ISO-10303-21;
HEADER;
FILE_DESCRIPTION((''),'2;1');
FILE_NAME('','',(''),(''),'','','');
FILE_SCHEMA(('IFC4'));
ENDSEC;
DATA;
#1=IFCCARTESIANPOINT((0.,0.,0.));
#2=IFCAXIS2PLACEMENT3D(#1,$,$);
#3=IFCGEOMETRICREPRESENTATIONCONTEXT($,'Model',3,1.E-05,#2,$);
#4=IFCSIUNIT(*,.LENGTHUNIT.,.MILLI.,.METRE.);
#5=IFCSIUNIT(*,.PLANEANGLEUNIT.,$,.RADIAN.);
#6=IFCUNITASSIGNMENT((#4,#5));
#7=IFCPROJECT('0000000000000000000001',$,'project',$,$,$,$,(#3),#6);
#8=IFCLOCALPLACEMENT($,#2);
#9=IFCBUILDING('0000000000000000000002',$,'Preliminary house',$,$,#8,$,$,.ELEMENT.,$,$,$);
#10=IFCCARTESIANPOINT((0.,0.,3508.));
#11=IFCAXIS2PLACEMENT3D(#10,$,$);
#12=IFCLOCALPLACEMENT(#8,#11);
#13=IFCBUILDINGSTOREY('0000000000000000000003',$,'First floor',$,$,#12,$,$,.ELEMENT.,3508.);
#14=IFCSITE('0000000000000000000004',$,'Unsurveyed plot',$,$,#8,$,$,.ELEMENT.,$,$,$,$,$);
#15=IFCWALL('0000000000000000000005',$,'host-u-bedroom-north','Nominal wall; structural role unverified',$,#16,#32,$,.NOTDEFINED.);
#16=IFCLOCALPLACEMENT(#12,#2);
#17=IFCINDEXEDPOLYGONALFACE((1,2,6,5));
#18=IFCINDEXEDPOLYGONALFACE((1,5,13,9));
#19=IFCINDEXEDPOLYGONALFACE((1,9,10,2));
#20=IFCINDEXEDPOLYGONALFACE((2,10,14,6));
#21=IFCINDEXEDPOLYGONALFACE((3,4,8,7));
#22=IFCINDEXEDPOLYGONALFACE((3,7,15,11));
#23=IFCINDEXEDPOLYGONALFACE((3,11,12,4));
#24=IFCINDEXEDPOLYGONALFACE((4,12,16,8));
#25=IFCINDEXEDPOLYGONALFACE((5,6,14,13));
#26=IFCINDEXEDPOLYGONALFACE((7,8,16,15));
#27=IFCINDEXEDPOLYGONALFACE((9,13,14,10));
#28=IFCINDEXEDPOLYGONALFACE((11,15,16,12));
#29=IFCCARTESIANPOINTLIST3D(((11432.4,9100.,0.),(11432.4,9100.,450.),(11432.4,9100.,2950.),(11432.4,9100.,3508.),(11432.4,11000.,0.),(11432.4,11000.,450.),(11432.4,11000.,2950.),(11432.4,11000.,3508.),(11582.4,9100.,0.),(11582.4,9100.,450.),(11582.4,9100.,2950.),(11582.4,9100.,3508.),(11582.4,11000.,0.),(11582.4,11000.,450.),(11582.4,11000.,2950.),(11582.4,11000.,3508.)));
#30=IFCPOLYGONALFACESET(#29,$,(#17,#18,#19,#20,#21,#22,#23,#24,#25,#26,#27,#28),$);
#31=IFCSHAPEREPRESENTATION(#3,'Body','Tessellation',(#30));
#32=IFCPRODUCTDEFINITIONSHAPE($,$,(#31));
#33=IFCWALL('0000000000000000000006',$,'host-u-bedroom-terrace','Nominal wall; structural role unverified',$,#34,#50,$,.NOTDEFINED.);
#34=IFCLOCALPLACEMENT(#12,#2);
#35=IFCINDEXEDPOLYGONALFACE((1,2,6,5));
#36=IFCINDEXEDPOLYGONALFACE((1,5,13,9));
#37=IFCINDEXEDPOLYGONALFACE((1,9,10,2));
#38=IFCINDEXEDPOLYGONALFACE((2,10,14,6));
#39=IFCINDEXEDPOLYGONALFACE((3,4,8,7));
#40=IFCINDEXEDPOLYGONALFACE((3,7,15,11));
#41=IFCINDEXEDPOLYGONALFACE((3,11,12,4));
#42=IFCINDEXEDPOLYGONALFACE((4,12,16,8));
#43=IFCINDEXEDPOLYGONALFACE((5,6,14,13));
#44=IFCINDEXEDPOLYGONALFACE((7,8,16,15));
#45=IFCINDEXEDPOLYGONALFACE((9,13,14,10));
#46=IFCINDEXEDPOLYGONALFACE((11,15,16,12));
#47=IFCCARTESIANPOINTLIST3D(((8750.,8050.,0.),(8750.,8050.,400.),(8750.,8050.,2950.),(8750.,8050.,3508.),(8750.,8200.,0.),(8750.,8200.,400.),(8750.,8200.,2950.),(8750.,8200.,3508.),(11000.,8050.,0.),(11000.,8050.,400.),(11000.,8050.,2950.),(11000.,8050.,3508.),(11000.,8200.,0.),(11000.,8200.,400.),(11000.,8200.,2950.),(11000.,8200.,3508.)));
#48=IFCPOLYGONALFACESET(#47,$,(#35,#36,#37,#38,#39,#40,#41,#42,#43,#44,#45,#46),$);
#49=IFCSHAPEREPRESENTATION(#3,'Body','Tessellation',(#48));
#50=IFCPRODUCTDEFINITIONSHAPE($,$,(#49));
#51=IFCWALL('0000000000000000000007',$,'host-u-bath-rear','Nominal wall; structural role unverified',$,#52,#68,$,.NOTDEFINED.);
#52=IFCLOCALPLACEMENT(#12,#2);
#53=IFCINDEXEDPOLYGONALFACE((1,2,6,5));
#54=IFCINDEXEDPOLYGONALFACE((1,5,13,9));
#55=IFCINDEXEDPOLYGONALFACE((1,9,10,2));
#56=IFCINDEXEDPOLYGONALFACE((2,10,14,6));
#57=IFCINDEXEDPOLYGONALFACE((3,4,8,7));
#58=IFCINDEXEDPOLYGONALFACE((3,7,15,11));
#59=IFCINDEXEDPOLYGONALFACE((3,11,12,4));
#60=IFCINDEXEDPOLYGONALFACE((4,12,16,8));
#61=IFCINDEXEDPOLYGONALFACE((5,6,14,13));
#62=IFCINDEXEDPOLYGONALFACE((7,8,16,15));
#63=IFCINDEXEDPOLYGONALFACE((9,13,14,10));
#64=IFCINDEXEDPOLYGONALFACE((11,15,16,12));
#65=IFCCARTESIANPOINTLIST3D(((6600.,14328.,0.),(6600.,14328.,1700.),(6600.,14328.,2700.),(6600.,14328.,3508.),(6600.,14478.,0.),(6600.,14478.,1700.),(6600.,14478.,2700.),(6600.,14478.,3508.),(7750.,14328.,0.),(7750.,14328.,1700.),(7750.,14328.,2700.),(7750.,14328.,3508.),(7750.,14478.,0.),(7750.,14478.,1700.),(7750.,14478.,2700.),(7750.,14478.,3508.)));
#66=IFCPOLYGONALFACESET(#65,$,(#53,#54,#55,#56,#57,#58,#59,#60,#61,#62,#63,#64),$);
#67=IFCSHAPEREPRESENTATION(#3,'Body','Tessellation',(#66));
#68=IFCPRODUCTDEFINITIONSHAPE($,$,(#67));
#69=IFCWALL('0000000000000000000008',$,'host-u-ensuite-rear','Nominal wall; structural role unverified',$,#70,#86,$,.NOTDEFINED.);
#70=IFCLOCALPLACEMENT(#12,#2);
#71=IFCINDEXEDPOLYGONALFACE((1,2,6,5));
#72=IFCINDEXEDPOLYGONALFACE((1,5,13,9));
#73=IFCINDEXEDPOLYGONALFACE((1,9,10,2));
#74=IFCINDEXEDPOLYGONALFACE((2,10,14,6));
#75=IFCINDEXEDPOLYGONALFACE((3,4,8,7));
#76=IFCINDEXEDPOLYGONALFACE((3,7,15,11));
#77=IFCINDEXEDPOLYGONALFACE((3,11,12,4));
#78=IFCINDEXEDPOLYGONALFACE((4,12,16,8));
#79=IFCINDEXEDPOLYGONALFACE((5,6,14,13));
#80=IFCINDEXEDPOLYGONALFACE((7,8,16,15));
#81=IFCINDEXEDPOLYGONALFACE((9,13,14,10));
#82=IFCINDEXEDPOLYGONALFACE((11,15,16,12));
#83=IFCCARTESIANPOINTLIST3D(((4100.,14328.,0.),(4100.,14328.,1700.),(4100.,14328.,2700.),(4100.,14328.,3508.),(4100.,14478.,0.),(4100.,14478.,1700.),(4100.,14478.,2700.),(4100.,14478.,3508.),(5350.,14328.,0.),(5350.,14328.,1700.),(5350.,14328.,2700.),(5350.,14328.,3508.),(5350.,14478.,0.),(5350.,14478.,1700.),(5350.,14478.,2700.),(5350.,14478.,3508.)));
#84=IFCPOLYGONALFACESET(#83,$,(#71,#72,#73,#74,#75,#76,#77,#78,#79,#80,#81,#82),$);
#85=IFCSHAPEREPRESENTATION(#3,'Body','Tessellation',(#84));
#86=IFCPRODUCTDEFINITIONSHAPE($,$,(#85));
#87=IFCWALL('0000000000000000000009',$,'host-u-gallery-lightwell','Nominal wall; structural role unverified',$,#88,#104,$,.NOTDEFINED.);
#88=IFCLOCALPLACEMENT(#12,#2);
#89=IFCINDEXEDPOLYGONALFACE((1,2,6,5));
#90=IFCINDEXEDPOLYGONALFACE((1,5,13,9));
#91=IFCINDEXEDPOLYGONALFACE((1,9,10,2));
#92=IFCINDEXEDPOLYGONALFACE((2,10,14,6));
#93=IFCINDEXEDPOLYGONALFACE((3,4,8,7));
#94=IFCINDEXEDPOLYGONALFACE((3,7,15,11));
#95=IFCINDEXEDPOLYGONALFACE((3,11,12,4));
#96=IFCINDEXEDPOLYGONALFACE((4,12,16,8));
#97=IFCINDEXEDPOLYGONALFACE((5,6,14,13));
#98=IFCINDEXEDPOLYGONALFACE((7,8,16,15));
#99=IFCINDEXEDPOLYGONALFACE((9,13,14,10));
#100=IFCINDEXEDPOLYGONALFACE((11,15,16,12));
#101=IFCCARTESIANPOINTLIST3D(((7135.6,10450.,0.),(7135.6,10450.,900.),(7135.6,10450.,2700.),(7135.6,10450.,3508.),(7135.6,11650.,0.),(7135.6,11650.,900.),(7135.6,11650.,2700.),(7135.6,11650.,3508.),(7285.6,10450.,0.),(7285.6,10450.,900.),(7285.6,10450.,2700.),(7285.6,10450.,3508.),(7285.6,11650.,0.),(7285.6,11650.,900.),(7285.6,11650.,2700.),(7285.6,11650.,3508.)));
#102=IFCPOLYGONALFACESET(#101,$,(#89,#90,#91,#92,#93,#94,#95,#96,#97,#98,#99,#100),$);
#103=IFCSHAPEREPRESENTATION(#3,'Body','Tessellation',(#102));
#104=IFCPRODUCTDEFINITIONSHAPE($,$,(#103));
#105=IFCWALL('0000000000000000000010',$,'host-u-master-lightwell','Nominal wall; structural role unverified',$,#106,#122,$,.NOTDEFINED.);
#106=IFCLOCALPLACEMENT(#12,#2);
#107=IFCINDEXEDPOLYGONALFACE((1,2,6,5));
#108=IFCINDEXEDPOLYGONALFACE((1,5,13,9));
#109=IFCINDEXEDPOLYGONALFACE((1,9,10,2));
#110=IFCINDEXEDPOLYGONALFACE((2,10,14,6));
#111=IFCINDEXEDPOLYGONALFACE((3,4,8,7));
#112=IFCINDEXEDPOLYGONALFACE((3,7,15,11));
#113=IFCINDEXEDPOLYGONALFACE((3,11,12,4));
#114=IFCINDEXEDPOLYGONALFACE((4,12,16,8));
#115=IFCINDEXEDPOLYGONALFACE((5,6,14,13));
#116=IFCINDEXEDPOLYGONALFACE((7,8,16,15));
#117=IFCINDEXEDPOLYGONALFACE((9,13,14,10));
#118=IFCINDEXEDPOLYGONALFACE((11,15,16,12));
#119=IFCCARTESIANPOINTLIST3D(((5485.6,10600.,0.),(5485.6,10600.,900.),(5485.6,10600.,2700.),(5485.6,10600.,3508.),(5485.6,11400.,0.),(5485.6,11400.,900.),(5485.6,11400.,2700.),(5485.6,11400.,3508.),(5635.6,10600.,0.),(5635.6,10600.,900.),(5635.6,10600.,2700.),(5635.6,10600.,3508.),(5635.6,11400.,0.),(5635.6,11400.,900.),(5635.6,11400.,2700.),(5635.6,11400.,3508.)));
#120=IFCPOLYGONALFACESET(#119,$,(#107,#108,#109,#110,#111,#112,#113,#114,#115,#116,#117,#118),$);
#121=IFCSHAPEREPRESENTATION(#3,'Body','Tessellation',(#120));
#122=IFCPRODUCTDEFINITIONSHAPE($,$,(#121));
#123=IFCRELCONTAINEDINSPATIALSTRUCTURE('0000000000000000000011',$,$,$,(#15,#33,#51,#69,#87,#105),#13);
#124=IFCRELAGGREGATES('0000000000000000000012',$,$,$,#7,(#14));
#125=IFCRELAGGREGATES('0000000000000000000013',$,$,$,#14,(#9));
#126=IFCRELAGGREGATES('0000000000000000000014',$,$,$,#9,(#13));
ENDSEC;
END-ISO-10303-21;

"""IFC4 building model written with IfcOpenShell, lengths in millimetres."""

from ifc_helpers import new_model, si_unit, frame, origin, place, context, project, spatial, polyline, outline, extrude, element, save


model = new_model("IFC4")

# Units and contexts
model_context = context("Model", 3, precision=1e-05, world=origin())
ifc_project = project(units=[si_unit("LENGTHUNIT", "METRE", prefix="MILLI"), si_unit("PLANEANGLEUNIT", "RADIAN")], contexts=[model_context])

# Site, building, storey
placement_1 = place(None, origin())
site = spatial("IfcSite", under=ifc_project, at=placement_1, Name="Unsurveyed plot", CompositionType="ELEMENT")
building = spatial("IfcBuilding", under=site, at=placement_1, Name="Preliminary house", CompositionType="ELEMENT")
placement_2 = place(placement_1, frame((0.0, 0.0, 3508.0)))
storey = spatial("IfcBuildingStorey", under=building, at=placement_2, Name="First floor", CompositionType="ELEMENT", Elevation=3508.0)

# Walls, openings
wall_1 = element("IfcWall", 1, at=placement_2, inside=storey, Name="host-u-bedroom-north", Description="Nominal wall; structural role unverified", PredefinedType="NOTDEFINED", context=model_context, shape_type="SweptSolid", body=[
    extrude(outline(polyline([(11432.4, 11000.0), (11582.4, 11000.0), (11582.4, 9100.0), (11432.4, 9100.0), (11432.4, 11000.0)])), origin(), (0.0, 0.0, 1.0), 3508.0),
])
element("IfcOpeningElement", 2, at=placement_2, cuts=wall_1, PredefinedType="OPENING", context=model_context, shape_type="SweptSolid", body=[
    extrude(outline(polyline([(11957.4, 9100.0), (11957.4, 11000.0), (11057.4, 11000.0), (11057.4, 9100.0), (11957.4, 9100.0)])), frame((0.0, 0.0, 450.0)), (0.0, 0.0, 1.0), 2500.0),
])
wall_2 = element("IfcWall", 3, at=placement_2, inside=storey, Name="host-u-bedroom-terrace", Description="Nominal wall; structural role unverified", PredefinedType="NOTDEFINED", context=model_context, shape_type="SweptSolid", body=[
    extrude(outline(polyline([(11000.0, 8200.0), (11000.0, 8050.0), (8750.0, 8050.0), (8750.0, 8200.0), (11000.0, 8200.0)])), origin(), (0.0, 0.0, 1.0), 3508.0),
])
element("IfcOpeningElement", 4, at=placement_2, cuts=wall_2, PredefinedType="OPENING", context=model_context, shape_type="SweptSolid", body=[
    extrude(outline(polyline([(8750.0, 7675.0), (11000.0, 7675.0), (11000.0, 8575.0), (8750.0, 8575.0), (8750.0, 7675.0)])), frame((0.0, 0.0, 400.0)), (0.0, 0.0, 1.0), 2550.0),
])
wall_3 = element("IfcWall", 5, at=placement_2, inside=storey, Name="host-u-bath-rear", Description="Nominal wall; structural role unverified", PredefinedType="NOTDEFINED", context=model_context, shape_type="SweptSolid", body=[
    extrude(outline(polyline([(7750.0, 14478.0), (7750.0, 14328.0), (6600.0, 14328.0), (6600.0, 14478.0), (7750.0, 14478.0)])), origin(), (0.0, 0.0, 1.0), 3508.0),
])
element("IfcOpeningElement", 6, at=placement_2, cuts=wall_3, PredefinedType="OPENING", context=model_context, shape_type="SweptSolid", body=[
    extrude(outline(polyline([(6600.0, 13953.0), (7750.0, 13953.0), (7750.0, 14853.0), (6600.0, 14853.0), (6600.0, 13953.0)])), frame((0.0, 0.0, 1700.0)), (0.0, 0.0, 1.0), 1000.0),
])
wall_4 = element("IfcWall", 7, at=placement_2, inside=storey, Name="host-u-ensuite-rear", Description="Nominal wall; structural role unverified", PredefinedType="NOTDEFINED", context=model_context, shape_type="SweptSolid", body=[
    extrude(outline(polyline([(5350.0, 14478.0), (5350.0, 14328.0), (4100.0, 14328.0), (4100.0, 14478.0), (5350.0, 14478.0)])), origin(), (0.0, 0.0, 1.0), 3508.0),
])
element("IfcOpeningElement", 8, at=placement_2, cuts=wall_4, PredefinedType="OPENING", context=model_context, shape_type="SweptSolid", body=[
    extrude(outline(polyline([(4100.0, 13953.0), (5350.0, 13953.0), (5350.0, 14853.0), (4100.0, 14853.0), (4100.0, 13953.0)])), frame((0.0, 0.0, 1700.0)), (0.0, 0.0, 1.0), 1000.0),
])
wall_5 = element("IfcWall", 9, at=placement_2, inside=storey, Name="host-u-gallery-lightwell", Description="Nominal wall; structural role unverified", PredefinedType="NOTDEFINED", context=model_context, shape_type="SweptSolid", body=[
    extrude(outline(polyline([(7135.6, 11650.0), (7285.6, 11650.0), (7285.6, 10450.0), (7135.6, 10450.0), (7135.6, 11650.0)])), origin(), (0.0, 0.0, 1.0), 3508.0),
])
element("IfcOpeningElement", 10, at=placement_2, cuts=wall_5, PredefinedType="OPENING", context=model_context, shape_type="SweptSolid", body=[
    extrude(outline(polyline([(7660.6, 10450.0), (7660.6, 11650.0), (6760.6, 11650.0), (6760.6, 10450.0), (7660.6, 10450.0)])), frame((0.0, 0.0, 900.0)), (0.0, 0.0, 1.0), 1800.0),
])
wall_6 = element("IfcWall", 11, at=placement_2, inside=storey, Name="host-u-master-lightwell", Description="Nominal wall; structural role unverified", PredefinedType="NOTDEFINED", context=model_context, shape_type="SweptSolid", body=[
    extrude(outline(polyline([(5485.6, 11400.0), (5635.6, 11400.0), (5635.6, 10600.0), (5485.6, 10600.0), (5485.6, 11400.0)])), origin(), (0.0, 0.0, 1.0), 3508.0),
])
element("IfcOpeningElement", 12, at=placement_2, cuts=wall_6, PredefinedType="OPENING", context=model_context, shape_type="SweptSolid", body=[
    extrude(outline(polyline([(6010.6, 10600.0), (6010.6, 11400.0), (5110.6, 11400.0), (5110.6, 10600.0), (6010.6, 10600.0)])), frame((0.0, 0.0, 900.0)), (0.0, 0.0, 1.0), 1800.0),
])

save(model, "model.ifc")
